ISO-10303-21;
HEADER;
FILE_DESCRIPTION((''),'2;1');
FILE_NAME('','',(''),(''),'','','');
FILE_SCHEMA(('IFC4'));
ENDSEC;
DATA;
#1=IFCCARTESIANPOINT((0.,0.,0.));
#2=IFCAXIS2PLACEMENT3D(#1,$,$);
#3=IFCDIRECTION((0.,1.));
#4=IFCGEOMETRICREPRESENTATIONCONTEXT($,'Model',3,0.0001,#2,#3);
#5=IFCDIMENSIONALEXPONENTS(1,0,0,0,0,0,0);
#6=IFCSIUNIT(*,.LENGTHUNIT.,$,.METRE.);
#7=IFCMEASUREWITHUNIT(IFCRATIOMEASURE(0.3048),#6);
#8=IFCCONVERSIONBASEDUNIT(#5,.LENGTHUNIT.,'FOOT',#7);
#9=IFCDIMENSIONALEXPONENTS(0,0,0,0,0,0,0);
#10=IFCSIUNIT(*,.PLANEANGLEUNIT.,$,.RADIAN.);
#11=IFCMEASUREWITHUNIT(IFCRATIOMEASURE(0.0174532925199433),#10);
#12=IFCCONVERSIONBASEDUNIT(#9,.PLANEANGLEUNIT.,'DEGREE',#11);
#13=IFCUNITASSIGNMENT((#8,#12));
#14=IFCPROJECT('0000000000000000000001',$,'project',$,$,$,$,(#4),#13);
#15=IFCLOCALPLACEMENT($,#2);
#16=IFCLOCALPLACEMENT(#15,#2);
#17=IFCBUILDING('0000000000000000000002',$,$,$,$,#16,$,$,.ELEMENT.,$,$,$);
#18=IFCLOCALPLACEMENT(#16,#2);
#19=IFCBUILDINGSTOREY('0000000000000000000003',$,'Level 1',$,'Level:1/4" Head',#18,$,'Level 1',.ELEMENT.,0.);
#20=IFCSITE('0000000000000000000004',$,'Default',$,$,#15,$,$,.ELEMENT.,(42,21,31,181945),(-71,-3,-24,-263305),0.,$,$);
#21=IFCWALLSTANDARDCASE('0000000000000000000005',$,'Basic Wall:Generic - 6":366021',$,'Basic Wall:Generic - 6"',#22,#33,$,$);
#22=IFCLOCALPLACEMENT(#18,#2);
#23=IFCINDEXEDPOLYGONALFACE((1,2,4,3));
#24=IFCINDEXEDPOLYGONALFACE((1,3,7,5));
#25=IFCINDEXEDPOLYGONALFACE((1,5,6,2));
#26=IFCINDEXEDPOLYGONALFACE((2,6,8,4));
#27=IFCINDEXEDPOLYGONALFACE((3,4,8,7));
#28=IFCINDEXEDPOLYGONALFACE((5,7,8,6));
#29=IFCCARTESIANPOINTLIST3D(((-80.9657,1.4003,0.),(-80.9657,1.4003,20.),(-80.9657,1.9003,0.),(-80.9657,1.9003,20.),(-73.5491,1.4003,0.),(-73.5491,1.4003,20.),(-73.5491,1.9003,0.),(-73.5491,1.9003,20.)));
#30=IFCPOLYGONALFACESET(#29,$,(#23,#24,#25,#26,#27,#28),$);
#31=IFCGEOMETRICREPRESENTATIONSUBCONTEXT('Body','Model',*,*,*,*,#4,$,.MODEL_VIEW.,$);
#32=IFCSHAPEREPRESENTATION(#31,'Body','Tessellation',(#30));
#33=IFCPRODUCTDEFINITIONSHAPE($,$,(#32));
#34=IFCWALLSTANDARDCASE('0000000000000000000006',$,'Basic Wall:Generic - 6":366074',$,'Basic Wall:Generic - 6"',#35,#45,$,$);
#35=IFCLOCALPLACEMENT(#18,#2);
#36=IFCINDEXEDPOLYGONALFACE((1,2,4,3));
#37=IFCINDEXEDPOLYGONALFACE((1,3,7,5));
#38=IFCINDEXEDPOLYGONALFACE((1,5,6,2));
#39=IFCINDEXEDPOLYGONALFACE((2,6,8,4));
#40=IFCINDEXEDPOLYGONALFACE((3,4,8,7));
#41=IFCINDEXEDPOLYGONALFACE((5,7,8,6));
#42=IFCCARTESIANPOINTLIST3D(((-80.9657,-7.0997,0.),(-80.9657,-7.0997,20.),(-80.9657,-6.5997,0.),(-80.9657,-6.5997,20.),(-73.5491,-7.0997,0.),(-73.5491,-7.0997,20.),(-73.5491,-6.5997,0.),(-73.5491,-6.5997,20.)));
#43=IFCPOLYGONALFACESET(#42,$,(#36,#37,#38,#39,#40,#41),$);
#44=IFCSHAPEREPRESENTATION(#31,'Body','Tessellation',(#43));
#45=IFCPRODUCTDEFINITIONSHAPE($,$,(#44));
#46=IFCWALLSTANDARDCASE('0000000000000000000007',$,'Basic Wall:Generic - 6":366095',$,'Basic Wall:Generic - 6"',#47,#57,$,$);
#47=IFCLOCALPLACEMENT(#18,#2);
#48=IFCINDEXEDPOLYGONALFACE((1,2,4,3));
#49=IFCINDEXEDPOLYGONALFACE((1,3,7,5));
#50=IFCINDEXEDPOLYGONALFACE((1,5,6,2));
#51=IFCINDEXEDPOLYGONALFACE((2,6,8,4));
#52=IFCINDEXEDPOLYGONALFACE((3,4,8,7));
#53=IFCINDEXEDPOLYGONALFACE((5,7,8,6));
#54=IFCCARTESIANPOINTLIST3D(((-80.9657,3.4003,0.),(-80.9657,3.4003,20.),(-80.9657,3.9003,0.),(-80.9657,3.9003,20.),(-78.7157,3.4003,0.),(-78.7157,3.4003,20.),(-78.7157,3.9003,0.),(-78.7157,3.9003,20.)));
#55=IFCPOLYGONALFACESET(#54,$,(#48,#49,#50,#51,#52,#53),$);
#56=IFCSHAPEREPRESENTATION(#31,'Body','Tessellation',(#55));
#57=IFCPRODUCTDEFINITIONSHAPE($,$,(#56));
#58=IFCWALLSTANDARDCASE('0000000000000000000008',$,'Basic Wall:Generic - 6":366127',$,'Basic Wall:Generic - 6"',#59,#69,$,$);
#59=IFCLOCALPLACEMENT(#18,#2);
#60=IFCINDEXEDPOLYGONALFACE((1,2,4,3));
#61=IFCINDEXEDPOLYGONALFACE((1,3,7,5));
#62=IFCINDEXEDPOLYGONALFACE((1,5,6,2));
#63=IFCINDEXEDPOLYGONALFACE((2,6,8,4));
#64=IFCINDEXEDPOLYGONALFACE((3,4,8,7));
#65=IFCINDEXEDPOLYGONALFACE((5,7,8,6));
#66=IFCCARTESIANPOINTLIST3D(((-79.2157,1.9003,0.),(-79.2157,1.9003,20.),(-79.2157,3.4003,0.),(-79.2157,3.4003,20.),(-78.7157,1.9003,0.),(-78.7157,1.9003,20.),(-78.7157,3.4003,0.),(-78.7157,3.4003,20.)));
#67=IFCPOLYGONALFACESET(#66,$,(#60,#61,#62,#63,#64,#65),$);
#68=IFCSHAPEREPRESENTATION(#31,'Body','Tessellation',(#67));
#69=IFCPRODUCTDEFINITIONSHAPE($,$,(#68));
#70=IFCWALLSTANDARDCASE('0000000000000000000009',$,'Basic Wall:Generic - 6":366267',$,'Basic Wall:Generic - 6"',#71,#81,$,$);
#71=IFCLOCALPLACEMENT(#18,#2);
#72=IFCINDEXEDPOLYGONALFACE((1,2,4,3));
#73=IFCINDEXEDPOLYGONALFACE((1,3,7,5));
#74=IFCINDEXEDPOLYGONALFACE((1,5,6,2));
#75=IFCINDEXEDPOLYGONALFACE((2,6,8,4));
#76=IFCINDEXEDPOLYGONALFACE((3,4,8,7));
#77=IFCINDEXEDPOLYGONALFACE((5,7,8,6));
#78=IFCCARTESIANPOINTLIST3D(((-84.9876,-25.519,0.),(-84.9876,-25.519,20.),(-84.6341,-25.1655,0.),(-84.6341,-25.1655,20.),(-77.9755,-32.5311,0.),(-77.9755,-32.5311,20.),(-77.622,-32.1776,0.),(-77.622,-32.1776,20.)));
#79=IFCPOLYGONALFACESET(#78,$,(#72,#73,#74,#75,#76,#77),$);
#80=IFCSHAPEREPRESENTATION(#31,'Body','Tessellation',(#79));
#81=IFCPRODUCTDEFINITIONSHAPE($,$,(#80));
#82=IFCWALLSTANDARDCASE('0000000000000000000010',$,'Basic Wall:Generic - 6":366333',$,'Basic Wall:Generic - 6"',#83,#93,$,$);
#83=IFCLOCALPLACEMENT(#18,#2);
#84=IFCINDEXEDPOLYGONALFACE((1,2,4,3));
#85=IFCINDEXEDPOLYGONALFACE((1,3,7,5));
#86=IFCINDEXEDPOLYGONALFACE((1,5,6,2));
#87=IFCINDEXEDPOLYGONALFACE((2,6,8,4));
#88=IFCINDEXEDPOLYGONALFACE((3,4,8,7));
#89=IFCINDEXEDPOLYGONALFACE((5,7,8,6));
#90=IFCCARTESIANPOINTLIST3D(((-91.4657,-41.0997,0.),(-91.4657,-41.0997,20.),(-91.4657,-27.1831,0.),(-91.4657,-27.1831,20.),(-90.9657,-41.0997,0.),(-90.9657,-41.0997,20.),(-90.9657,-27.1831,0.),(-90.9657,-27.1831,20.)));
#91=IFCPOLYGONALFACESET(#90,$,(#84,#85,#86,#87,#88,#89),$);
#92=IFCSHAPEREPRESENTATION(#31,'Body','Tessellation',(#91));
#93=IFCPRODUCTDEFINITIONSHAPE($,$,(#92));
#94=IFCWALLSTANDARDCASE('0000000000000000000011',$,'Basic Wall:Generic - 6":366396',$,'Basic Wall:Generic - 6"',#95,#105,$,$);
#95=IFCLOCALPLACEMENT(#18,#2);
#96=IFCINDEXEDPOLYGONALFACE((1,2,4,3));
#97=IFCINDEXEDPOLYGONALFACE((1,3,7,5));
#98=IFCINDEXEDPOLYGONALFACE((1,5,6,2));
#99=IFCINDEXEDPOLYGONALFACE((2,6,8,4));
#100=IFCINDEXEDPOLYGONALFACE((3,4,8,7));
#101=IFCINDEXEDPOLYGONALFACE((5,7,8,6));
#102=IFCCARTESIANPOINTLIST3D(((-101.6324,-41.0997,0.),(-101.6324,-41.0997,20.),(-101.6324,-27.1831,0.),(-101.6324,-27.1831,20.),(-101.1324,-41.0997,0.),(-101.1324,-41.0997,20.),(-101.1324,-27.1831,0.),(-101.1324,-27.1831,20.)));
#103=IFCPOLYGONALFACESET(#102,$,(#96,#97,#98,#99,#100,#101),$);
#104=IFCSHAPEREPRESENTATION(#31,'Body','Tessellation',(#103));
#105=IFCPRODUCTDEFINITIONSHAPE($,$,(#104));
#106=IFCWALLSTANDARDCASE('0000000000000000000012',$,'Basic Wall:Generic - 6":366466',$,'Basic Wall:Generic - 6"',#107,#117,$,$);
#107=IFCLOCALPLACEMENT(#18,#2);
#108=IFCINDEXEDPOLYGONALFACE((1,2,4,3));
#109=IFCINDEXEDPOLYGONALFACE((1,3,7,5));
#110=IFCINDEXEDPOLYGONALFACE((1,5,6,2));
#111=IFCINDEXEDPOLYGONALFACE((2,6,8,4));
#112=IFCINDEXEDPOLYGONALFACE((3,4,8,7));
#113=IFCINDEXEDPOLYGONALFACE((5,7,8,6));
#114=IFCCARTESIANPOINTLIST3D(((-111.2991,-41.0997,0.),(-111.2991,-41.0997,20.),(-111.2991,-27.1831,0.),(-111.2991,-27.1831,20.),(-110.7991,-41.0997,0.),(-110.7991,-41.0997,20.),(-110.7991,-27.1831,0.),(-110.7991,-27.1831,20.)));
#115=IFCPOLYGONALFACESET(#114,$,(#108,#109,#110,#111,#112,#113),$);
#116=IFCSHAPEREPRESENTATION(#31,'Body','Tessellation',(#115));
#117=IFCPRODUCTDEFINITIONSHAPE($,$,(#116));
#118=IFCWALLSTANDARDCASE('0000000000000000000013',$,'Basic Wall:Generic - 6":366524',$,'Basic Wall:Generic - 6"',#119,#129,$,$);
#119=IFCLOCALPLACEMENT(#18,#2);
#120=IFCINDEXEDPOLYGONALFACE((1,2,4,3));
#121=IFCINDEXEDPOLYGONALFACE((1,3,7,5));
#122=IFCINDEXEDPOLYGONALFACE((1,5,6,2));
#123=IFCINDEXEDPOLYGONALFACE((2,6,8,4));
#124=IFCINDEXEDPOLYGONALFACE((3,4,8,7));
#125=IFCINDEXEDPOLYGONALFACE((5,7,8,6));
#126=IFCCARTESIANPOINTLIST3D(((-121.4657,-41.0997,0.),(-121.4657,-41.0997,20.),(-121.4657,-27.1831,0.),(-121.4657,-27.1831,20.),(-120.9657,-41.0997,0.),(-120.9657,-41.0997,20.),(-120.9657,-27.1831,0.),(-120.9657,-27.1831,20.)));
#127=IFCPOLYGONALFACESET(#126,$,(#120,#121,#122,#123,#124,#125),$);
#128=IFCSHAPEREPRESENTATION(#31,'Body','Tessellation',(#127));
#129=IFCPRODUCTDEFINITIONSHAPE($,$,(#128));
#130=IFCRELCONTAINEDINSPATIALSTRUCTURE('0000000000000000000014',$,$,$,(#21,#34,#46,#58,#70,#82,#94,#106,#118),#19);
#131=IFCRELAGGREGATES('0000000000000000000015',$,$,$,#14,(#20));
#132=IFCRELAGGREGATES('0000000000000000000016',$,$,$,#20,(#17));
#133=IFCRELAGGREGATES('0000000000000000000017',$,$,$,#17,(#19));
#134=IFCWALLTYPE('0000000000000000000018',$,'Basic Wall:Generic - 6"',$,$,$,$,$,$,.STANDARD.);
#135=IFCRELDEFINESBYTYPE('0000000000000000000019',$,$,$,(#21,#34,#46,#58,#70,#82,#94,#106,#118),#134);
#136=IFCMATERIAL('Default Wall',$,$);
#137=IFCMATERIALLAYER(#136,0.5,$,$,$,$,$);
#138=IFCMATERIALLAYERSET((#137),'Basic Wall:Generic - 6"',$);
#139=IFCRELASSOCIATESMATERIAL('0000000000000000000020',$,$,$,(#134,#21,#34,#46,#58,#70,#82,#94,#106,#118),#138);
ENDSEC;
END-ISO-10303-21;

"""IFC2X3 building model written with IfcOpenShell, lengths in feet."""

from ifc_helpers import new_model, entity, si_unit, converted_unit, direction, frame, frame_2d, origin, place, context, subcontext, project, spatial, rectangle, extrude, material, layer, layer_set, layer_usage, type_object, element, save


model = new_model("IFC2X3")

# Units and contexts
model_context = context("Model", 3, precision=0.0001, world=origin(), true_north=direction((0.0, 1.0)))
body_context = subcontext(model_context, "Body", "Model", "MODEL_VIEW")
ifc_project = project(units=[converted_unit("LENGTHUNIT", "FOOT", entity("IfcRatioMeasure", 0.3048), si_unit("LENGTHUNIT", "METRE"), dimensions=[1, 0, 0, 0, 0, 0, 0]), converted_unit("PLANEANGLEUNIT", "DEGREE", entity("IfcRatioMeasure", 0.0174532925199433), si_unit("PLANEANGLEUNIT", "RADIAN"), dimensions=[0, 0, 0, 0, 0, 0, 0])], contexts=[model_context])

# Site, building, storey
site_placement = place(None, origin())
site = spatial("IfcSite", under=ifc_project, at=site_placement, Name="Default", CompositionType="ELEMENT", RefLatitude=(42, 21, 31, 181945), RefLongitude=(-71, -3, -24, -263305), RefElevation=0.0)
building_placement = place(site_placement, origin())
building = spatial("IfcBuilding", under=site, at=building_placement, CompositionType="ELEMENT")
storey_placement = place(building_placement, origin())
storey = spatial("IfcBuildingStorey", under=building, at=storey_placement, Name="Level 1", ObjectType="Level:1/4\" Head", LongName="Level 1", CompositionType="ELEMENT", Elevation=0.0)

# Shared definitions
ifc_material = material(Name="Default Wall")
ifc_layer_1 = layer(ifc_material, 0.5)
ifc_layer_set_1 = layer_set([ifc_layer_1], Name="Basic Wall:Generic - 6\"")
wall_type_1 = type_object("IfcWallType", Name="Basic Wall:Generic - 6\"", PredefinedType="STANDARD", material=ifc_layer_set_1)

# Walls
ifc_layer_usage_1 = layer_usage(ifc_layer_set_1, "AXIS2", "NEGATIVE", 0.25)
wall_1_placement = place(storey_placement, frame((-80.9657, 1.6503, 0.0)))
element("IfcWallStandardCase", 1, at=wall_1_placement, inside=storey, type_object=wall_type_1, material=ifc_layer_usage_1, Name="Basic Wall:Generic - 6\":366021", ObjectType="Basic Wall:Generic - 6\"", context=body_context, shape_type="SweptSolid", body=[
    extrude(rectangle(XDim=7.4167, YDim=0.5, at=frame_2d((3.7083, 0.0), x_axis=(-1.0, 0.0))), origin(), (0.0, 0.0, 1.0), 20.0),
])
ifc_layer_usage_2 = layer_usage(ifc_layer_set_1, "AXIS2", "NEGATIVE", 0.25)
wall_2_placement = place(storey_placement, frame((-80.9657, -6.8497, 0.0)))
element("IfcWallStandardCase", 2, at=wall_2_placement, inside=storey, type_object=wall_type_1, material=ifc_layer_usage_2, Name="Basic Wall:Generic - 6\":366074", ObjectType="Basic Wall:Generic - 6\"", context=body_context, shape_type="SweptSolid", body=[
    extrude(rectangle(XDim=7.4167, YDim=0.5, at=frame_2d((3.7083, 0.0), x_axis=(-1.0, 0.0))), origin(), (0.0, 0.0, 1.0), 20.0),
])
ifc_layer_usage_3 = layer_usage(ifc_layer_set_1, "AXIS2", "NEGATIVE", 0.25)
wall_3_placement = place(storey_placement, frame((-80.9657, 3.6503, 0.0)))
element("IfcWallStandardCase", 3, at=wall_3_placement, inside=storey, type_object=wall_type_1, material=ifc_layer_usage_3, Name="Basic Wall:Generic - 6\":366095", ObjectType="Basic Wall:Generic - 6\"", context=body_context, shape_type="SweptSolid", body=[
    extrude(rectangle(XDim=2.25, YDim=0.5, at=frame_2d((1.125, 0.0), x_axis=(-1.0, 0.0))), origin(), (0.0, 0.0, 1.0), 20.0),
])
ifc_layer_usage_4 = layer_usage(ifc_layer_set_1, "AXIS2", "NEGATIVE", 0.25)
wall_4_placement = place(storey_placement, frame((-78.9657, 3.4003, 0.0), z_axis=(0.0, 0.0, 1.0), x_axis=(0.0, -1.0, 0.0)))
element("IfcWallStandardCase", 4, at=wall_4_placement, inside=storey, type_object=wall_type_1, material=ifc_layer_usage_4, Name="Basic Wall:Generic - 6\":366127", ObjectType="Basic Wall:Generic - 6\"", context=body_context, shape_type="SweptSolid", body=[
    extrude(rectangle(XDim=1.5, YDim=0.5, at=frame_2d((0.75, 0.0), x_axis=(-1.0, 0.0))), origin(), (0.0, 0.0, 1.0), 20.0),
])
ifc_layer_usage_5 = layer_usage(ifc_layer_set_1, "AXIS2", "NEGATIVE", 0.25)
wall_5_placement = place(storey_placement, frame((-77.7988, -32.3544, 0.0), z_axis=(0.0, 0.0, 1.0), x_axis=(-0.707107, 0.707107, 0.0)))
element("IfcWallStandardCase", 5, at=wall_5_placement, inside=storey, type_object=wall_type_1, material=ifc_layer_usage_5, Name="Basic Wall:Generic - 6\":366267", ObjectType="Basic Wall:Generic - 6\"", context=body_context, shape_type="SweptSolid", body=[
    extrude(rectangle(XDim=9.9166, YDim=0.5, at=frame_2d((4.9583, 0.0), x_axis=(-1.0, 0.0))), origin(), (0.0, 0.0, 1.0), 20.0),
])
ifc_layer_usage_6 = layer_usage(ifc_layer_set_1, "AXIS2", "NEGATIVE", 0.25)
wall_6_placement = place(storey_placement, frame((-91.2157, -27.1831, 0.0), z_axis=(0.0, 0.0, 1.0), x_axis=(0.0, -1.0, 0.0)))
element("IfcWallStandardCase", 6, at=wall_6_placement, inside=storey, type_object=wall_type_1, material=ifc_layer_usage_6, Name="Basic Wall:Generic - 6\":366333", ObjectType="Basic Wall:Generic - 6\"", context=body_context, shape_type="SweptSolid", body=[
    extrude(rectangle(XDim=13.9167, YDim=0.5, at=frame_2d((6.9583, 0.0), x_axis=(-1.0, 0.0))), origin(), (0.0, 0.0, 1.0), 20.0),
])
ifc_layer_usage_7 = layer_usage(ifc_layer_set_1, "AXIS2", "NEGATIVE", 0.25)
wall_7_placement = place(storey_placement, frame((-101.3824, -41.0997, 0.0), z_axis=(0.0, 0.0, 1.0), x_axis=(0.0, 1.0, 0.0)))
element("IfcWallStandardCase", 7, at=wall_7_placement, inside=storey, type_object=wall_type_1, material=ifc_layer_usage_7, Name="Basic Wall:Generic - 6\":366396", ObjectType="Basic Wall:Generic - 6\"", context=body_context, shape_type="SweptSolid", body=[
    extrude(rectangle(XDim=13.9167, YDim=0.5, at=frame_2d((6.9583, 0.0), x_axis=(-1.0, 0.0))), origin(), (0.0, 0.0, 1.0), 20.0),
])
ifc_layer_usage_8 = layer_usage(ifc_layer_set_1, "AXIS2", "NEGATIVE", 0.25)
wall_8_placement = place(storey_placement, frame((-111.0491, -27.1831, 0.0), z_axis=(0.0, 0.0, 1.0), x_axis=(0.0, -1.0, 0.0)))
element("IfcWallStandardCase", 8, at=wall_8_placement, inside=storey, type_object=wall_type_1, material=ifc_layer_usage_8, Name="Basic Wall:Generic - 6\":366466", ObjectType="Basic Wall:Generic - 6\"", context=body_context, shape_type="SweptSolid", body=[
    extrude(rectangle(XDim=13.9167, YDim=0.5, at=frame_2d((6.9583, 0.0), x_axis=(-1.0, 0.0))), origin(), (0.0, 0.0, 1.0), 20.0),
])
ifc_layer_usage_9 = layer_usage(ifc_layer_set_1, "AXIS2", "NEGATIVE", 0.25)
wall_9_placement = place(storey_placement, frame((-121.2157, -41.0997, 0.0), z_axis=(0.0, 0.0, 1.0), x_axis=(0.0, 1.0, 0.0)))
element("IfcWallStandardCase", 9, at=wall_9_placement, inside=storey, type_object=wall_type_1, material=ifc_layer_usage_9, Name="Basic Wall:Generic - 6\":366524", ObjectType="Basic Wall:Generic - 6\"", context=body_context, shape_type="SweptSolid", body=[
    extrude(rectangle(XDim=13.9167, YDim=0.5, at=frame_2d((6.9583, 0.0), x_axis=(-1.0, 0.0))), origin(), (0.0, 0.0, 1.0), 20.0),
])

save(model, "model.ifc")
